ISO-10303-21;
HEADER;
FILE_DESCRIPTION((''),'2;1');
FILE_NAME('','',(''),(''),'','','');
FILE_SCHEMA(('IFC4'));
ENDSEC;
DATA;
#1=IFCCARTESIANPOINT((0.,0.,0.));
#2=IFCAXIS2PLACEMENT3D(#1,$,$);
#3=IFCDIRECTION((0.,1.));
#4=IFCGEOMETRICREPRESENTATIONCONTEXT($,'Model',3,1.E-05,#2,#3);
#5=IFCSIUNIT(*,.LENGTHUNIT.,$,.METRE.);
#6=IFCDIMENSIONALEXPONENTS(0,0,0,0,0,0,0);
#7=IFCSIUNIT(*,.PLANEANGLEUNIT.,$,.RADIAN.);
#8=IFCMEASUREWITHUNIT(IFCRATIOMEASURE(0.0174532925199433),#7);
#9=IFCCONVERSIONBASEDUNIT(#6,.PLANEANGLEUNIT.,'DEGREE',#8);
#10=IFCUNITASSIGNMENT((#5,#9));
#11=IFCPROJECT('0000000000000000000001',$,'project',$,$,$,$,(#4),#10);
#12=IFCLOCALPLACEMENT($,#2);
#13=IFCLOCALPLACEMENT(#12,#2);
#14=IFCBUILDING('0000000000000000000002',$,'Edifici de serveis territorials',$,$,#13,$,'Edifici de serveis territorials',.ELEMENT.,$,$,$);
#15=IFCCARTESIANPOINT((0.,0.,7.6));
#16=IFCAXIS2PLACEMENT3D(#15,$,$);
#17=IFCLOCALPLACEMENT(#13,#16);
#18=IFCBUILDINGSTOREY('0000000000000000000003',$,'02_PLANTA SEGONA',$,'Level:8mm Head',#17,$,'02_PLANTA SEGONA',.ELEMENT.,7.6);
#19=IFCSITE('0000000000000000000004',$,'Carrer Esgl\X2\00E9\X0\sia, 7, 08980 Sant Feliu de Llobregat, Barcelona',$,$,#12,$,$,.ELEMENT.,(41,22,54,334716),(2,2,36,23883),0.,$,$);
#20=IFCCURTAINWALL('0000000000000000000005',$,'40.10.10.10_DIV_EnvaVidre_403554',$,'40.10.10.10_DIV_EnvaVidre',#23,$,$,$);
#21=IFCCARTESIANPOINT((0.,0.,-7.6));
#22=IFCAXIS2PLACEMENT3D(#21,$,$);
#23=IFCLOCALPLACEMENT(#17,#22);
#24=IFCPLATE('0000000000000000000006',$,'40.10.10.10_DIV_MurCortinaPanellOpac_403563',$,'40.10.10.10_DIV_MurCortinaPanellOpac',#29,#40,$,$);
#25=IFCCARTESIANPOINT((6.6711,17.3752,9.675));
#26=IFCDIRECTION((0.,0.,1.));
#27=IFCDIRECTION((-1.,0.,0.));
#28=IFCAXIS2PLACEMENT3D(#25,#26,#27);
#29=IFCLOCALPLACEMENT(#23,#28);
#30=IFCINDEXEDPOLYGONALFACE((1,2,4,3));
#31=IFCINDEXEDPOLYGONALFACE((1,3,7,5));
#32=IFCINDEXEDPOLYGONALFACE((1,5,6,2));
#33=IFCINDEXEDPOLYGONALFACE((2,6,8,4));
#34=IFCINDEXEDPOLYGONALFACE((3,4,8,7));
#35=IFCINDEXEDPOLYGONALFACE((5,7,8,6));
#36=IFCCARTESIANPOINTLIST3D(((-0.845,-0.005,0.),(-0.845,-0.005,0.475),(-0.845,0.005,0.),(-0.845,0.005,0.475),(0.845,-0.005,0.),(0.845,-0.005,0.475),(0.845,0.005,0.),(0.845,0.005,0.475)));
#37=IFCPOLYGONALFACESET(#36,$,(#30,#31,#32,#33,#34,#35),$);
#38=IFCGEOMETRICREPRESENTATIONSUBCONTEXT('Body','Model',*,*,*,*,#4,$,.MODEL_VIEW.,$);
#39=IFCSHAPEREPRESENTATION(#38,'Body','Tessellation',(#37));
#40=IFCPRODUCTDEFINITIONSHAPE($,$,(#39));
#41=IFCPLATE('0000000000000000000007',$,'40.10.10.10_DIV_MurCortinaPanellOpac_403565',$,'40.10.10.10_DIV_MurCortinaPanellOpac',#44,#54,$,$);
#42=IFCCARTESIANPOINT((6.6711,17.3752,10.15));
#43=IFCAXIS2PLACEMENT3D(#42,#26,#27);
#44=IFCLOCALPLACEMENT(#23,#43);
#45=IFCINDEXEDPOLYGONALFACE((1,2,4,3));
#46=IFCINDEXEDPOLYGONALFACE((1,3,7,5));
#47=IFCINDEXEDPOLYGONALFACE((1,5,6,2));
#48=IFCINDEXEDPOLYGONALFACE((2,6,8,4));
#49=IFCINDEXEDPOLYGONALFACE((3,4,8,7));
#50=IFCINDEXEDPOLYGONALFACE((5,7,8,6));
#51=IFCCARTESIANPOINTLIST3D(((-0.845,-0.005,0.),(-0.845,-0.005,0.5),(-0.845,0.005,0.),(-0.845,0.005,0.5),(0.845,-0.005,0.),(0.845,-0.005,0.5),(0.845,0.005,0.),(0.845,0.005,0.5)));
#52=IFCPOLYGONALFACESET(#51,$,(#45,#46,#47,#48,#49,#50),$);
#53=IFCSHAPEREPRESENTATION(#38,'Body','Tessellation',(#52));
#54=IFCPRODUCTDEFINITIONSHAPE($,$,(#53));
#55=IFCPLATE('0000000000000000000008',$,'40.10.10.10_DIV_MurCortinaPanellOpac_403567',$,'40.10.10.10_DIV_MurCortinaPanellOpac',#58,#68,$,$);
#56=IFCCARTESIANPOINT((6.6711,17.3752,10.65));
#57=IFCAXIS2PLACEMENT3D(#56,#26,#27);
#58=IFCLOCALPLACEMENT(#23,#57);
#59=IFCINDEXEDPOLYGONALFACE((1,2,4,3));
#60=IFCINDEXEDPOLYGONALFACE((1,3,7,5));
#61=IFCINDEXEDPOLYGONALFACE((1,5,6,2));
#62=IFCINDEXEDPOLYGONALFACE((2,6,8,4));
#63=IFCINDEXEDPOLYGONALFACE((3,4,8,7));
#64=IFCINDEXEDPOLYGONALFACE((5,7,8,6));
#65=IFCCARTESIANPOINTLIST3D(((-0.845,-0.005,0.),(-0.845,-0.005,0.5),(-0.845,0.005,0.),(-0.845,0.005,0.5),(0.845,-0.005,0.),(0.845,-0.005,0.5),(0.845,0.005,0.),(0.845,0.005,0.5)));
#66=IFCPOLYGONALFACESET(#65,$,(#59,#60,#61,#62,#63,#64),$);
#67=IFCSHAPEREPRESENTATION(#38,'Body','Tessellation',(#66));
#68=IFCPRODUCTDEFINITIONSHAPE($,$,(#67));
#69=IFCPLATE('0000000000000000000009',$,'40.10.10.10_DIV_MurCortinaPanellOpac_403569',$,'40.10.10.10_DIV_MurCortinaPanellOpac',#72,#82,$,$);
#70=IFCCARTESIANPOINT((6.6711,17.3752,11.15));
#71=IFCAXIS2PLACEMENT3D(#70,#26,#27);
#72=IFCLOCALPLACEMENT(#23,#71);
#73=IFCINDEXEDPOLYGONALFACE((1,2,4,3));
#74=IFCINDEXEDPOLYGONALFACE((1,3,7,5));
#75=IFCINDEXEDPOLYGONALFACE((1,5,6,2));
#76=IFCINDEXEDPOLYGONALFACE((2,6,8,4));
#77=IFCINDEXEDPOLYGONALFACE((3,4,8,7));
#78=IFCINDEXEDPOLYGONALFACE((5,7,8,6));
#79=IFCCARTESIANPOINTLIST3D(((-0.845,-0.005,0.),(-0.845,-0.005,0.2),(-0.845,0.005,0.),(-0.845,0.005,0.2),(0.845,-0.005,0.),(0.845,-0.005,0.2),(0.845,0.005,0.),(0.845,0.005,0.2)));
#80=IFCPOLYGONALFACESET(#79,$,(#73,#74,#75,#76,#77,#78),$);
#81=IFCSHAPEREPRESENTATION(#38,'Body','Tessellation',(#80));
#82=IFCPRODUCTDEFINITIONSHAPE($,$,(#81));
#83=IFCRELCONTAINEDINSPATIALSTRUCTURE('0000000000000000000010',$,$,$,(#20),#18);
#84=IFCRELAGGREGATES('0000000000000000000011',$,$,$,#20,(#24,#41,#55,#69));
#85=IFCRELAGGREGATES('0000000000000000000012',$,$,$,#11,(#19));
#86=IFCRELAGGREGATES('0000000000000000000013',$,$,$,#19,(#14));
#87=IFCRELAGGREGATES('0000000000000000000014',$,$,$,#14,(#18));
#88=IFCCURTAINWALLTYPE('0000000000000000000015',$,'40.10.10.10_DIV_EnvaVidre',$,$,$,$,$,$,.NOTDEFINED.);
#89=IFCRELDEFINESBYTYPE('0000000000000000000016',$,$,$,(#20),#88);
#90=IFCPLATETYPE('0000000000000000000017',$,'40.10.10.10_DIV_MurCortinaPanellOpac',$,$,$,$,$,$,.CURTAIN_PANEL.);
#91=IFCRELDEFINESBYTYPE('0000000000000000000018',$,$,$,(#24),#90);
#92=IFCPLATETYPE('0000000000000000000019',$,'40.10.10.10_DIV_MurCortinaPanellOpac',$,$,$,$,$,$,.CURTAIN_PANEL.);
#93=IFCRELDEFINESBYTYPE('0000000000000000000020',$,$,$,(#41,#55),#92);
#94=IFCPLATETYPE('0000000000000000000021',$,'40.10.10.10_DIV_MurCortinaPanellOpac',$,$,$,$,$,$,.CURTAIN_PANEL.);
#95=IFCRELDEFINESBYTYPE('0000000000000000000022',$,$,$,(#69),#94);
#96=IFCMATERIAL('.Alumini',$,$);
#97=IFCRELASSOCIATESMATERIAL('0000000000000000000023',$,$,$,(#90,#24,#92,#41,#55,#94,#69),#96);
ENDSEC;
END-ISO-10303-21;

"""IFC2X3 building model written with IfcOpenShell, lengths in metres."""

from ifc_helpers import new_model, entity, si_unit, converted_unit, direction, frame, origin, origin_2d_with_axis, place, context, subcontext, project, spatial, rectangle, extrude, source, transform, mapped, material, type_object, type_shapes, element, aggregate, save


model = new_model("IFC2X3")

# Units and contexts
model_context = context("Model", 3, precision=1e-05, world=origin(), true_north=direction((0.0, 1.0)))
body_context = subcontext(model_context, "Body", "Model", "MODEL_VIEW")
ifc_project = project(units=[si_unit("LENGTHUNIT", "METRE"), converted_unit("PLANEANGLEUNIT", "DEGREE", entity("IfcRatioMeasure", 0.0174532925199433), si_unit("PLANEANGLEUNIT", "RADIAN"), dimensions=[0, 0, 0, 0, 0, 0, 0])], contexts=[model_context])

# Site, building, storey
site_placement = place(None, origin())
site = spatial("IfcSite", under=ifc_project, at=site_placement, Name="Carrer Església, 7, 08980 Sant Feliu de Llobregat, Barcelona", CompositionType="ELEMENT", RefLatitude=(41, 22, 54, 334716), RefLongitude=(2, 2, 36, 23883), RefElevation=0.0)
building_placement = place(site_placement, origin())
building = spatial("IfcBuilding", under=site, at=building_placement, Name="Edifici de serveis territorials", LongName="Edifici de serveis territorials", CompositionType="ELEMENT")
storey_placement = place(building_placement, frame((0.0, 0.0, 7.6)))
storey = spatial("IfcBuildingStorey", under=building, at=storey_placement, Name="02_PLANTA SEGONA", ObjectType="Level:8mm Head", LongName="02_PLANTA SEGONA", CompositionType="ELEMENT", Elevation=7.6)

# Curtain wall
curtain_wall_type = type_object("IfcCurtainWallType", Name="40.10.10.10_DIV_EnvaVidre", PredefinedType="NOTDEFINED")
curtain_wall_1_placement = place(storey_placement, frame((0.0, 0.0, -7.6)))
curtain_wall_1 = element("IfcCurtainWall", 1, at=curtain_wall_1_placement, inside=storey, type_object=curtain_wall_type, Name="40.10.10.10_DIV_EnvaVidre_403554", ObjectType="40.10.10.10_DIV_EnvaVidre")

# Plates
ifc_material_1 = material(Name=".Alumini")
plate_type_1 = type_object("IfcPlateType", Name="40.10.10.10_DIV_MurCortinaPanellOpac", PredefinedType="CURTAIN_PANEL", material=ifc_material_1)
shared_shape_1 = source(origin(), body_context, "Body", "SweptSolid", [
    extrude(rectangle(XDim=0.01, YDim=1.69, at=origin_2d_with_axis()), frame((0.0, 0.0, 0.0), z_axis=(0.0, 0.0, 1.0), x_axis=(0.0, 1.0, 0.0)), (0.0, 0.0, 1.0), 0.475),
])
type_shapes(plate_type_1, [shared_shape_1])
plate_1_placement = place(curtain_wall_1_placement, frame((6.6711, 17.3752, 9.675), z_axis=(0.0, 0.0, 1.0), x_axis=(-1.0, 0.0, 0.0)))
plate_1 = element("IfcPlate", 2, at=plate_1_placement, type_object=plate_type_1, material=ifc_material_1, Name="40.10.10.10_DIV_MurCortinaPanellOpac_403563", ObjectType="40.10.10.10_DIV_MurCortinaPanellOpac", context=body_context, shape_type="MappedRepresentation", body=[
    mapped(shared_shape_1, transform((0.0, 0.0, 0.0), scale=1.0)),
])
plate_type_2 = type_object("IfcPlateType", Name="40.10.10.10_DIV_MurCortinaPanellOpac", PredefinedType="CURTAIN_PANEL", material=ifc_material_1)
shared_shape_2 = source(origin(), body_context, "Body", "SweptSolid", [
    extrude(rectangle(XDim=0.01, YDim=1.69, at=origin_2d_with_axis()), frame((0.0, 0.0, 0.0), z_axis=(0.0, 0.0, 1.0), x_axis=(0.0, 1.0, 0.0)), (0.0, 0.0, 1.0), 0.5),
])
type_shapes(plate_type_2, [shared_shape_2])
plate_2_placement = place(curtain_wall_1_placement, frame((6.6711, 17.3752, 10.15), z_axis=(0.0, 0.0, 1.0), x_axis=(-1.0, 0.0, 0.0)))
plate_2 = element("IfcPlate", 3, at=plate_2_placement, type_object=plate_type_2, material=ifc_material_1, Name="40.10.10.10_DIV_MurCortinaPanellOpac_403565", ObjectType="40.10.10.10_DIV_MurCortinaPanellOpac", context=body_context, shape_type="MappedRepresentation", body=[
    mapped(shared_shape_2, transform((0.0, 0.0, 0.0), scale=1.0)),
])
plate_3_placement = place(curtain_wall_1_placement, frame((6.6711, 17.3752, 10.65), z_axis=(0.0, 0.0, 1.0), x_axis=(-1.0, 0.0, 0.0)))
plate_3 = element("IfcPlate", 4, at=plate_3_placement, type_object=plate_type_2, material=ifc_material_1, Name="40.10.10.10_DIV_MurCortinaPanellOpac_403567", ObjectType="40.10.10.10_DIV_MurCortinaPanellOpac", context=body_context, shape_type="MappedRepresentation", body=[
    mapped(shared_shape_2, transform((0.0, 0.0, 0.0), scale=1.0)),
])
plate_type_3 = type_object("IfcPlateType", Name="40.10.10.10_DIV_MurCortinaPanellOpac", PredefinedType="CURTAIN_PANEL", material=ifc_material_1)
shared_shape_3 = source(origin(), body_context, "Body", "SweptSolid", [
    extrude(rectangle(XDim=0.01, YDim=1.69, at=origin_2d_with_axis()), frame((0.0, 0.0, 0.0), z_axis=(0.0, 0.0, 1.0), x_axis=(0.0, 1.0, 0.0)), (0.0, 0.0, 1.0), 0.2),
])
type_shapes(plate_type_3, [shared_shape_3])
plate_4_placement = place(curtain_wall_1_placement, frame((6.6711, 17.3752, 11.15), z_axis=(0.0, 0.0, 1.0), x_axis=(-1.0, 0.0, 0.0)))
plate_4 = element("IfcPlate", 5, at=plate_4_placement, type_object=plate_type_3, material=ifc_material_1, Name="40.10.10.10_DIV_MurCortinaPanellOpac_403569", ObjectType="40.10.10.10_DIV_MurCortinaPanellOpac", context=body_context, shape_type="MappedRepresentation", body=[
    mapped(shared_shape_3, transform((0.0, 0.0, 0.0), scale=1.0)),
])
aggregate(curtain_wall_1, [plate_1, plate_2, plate_3, plate_4])

save(model, "model.ifc")
